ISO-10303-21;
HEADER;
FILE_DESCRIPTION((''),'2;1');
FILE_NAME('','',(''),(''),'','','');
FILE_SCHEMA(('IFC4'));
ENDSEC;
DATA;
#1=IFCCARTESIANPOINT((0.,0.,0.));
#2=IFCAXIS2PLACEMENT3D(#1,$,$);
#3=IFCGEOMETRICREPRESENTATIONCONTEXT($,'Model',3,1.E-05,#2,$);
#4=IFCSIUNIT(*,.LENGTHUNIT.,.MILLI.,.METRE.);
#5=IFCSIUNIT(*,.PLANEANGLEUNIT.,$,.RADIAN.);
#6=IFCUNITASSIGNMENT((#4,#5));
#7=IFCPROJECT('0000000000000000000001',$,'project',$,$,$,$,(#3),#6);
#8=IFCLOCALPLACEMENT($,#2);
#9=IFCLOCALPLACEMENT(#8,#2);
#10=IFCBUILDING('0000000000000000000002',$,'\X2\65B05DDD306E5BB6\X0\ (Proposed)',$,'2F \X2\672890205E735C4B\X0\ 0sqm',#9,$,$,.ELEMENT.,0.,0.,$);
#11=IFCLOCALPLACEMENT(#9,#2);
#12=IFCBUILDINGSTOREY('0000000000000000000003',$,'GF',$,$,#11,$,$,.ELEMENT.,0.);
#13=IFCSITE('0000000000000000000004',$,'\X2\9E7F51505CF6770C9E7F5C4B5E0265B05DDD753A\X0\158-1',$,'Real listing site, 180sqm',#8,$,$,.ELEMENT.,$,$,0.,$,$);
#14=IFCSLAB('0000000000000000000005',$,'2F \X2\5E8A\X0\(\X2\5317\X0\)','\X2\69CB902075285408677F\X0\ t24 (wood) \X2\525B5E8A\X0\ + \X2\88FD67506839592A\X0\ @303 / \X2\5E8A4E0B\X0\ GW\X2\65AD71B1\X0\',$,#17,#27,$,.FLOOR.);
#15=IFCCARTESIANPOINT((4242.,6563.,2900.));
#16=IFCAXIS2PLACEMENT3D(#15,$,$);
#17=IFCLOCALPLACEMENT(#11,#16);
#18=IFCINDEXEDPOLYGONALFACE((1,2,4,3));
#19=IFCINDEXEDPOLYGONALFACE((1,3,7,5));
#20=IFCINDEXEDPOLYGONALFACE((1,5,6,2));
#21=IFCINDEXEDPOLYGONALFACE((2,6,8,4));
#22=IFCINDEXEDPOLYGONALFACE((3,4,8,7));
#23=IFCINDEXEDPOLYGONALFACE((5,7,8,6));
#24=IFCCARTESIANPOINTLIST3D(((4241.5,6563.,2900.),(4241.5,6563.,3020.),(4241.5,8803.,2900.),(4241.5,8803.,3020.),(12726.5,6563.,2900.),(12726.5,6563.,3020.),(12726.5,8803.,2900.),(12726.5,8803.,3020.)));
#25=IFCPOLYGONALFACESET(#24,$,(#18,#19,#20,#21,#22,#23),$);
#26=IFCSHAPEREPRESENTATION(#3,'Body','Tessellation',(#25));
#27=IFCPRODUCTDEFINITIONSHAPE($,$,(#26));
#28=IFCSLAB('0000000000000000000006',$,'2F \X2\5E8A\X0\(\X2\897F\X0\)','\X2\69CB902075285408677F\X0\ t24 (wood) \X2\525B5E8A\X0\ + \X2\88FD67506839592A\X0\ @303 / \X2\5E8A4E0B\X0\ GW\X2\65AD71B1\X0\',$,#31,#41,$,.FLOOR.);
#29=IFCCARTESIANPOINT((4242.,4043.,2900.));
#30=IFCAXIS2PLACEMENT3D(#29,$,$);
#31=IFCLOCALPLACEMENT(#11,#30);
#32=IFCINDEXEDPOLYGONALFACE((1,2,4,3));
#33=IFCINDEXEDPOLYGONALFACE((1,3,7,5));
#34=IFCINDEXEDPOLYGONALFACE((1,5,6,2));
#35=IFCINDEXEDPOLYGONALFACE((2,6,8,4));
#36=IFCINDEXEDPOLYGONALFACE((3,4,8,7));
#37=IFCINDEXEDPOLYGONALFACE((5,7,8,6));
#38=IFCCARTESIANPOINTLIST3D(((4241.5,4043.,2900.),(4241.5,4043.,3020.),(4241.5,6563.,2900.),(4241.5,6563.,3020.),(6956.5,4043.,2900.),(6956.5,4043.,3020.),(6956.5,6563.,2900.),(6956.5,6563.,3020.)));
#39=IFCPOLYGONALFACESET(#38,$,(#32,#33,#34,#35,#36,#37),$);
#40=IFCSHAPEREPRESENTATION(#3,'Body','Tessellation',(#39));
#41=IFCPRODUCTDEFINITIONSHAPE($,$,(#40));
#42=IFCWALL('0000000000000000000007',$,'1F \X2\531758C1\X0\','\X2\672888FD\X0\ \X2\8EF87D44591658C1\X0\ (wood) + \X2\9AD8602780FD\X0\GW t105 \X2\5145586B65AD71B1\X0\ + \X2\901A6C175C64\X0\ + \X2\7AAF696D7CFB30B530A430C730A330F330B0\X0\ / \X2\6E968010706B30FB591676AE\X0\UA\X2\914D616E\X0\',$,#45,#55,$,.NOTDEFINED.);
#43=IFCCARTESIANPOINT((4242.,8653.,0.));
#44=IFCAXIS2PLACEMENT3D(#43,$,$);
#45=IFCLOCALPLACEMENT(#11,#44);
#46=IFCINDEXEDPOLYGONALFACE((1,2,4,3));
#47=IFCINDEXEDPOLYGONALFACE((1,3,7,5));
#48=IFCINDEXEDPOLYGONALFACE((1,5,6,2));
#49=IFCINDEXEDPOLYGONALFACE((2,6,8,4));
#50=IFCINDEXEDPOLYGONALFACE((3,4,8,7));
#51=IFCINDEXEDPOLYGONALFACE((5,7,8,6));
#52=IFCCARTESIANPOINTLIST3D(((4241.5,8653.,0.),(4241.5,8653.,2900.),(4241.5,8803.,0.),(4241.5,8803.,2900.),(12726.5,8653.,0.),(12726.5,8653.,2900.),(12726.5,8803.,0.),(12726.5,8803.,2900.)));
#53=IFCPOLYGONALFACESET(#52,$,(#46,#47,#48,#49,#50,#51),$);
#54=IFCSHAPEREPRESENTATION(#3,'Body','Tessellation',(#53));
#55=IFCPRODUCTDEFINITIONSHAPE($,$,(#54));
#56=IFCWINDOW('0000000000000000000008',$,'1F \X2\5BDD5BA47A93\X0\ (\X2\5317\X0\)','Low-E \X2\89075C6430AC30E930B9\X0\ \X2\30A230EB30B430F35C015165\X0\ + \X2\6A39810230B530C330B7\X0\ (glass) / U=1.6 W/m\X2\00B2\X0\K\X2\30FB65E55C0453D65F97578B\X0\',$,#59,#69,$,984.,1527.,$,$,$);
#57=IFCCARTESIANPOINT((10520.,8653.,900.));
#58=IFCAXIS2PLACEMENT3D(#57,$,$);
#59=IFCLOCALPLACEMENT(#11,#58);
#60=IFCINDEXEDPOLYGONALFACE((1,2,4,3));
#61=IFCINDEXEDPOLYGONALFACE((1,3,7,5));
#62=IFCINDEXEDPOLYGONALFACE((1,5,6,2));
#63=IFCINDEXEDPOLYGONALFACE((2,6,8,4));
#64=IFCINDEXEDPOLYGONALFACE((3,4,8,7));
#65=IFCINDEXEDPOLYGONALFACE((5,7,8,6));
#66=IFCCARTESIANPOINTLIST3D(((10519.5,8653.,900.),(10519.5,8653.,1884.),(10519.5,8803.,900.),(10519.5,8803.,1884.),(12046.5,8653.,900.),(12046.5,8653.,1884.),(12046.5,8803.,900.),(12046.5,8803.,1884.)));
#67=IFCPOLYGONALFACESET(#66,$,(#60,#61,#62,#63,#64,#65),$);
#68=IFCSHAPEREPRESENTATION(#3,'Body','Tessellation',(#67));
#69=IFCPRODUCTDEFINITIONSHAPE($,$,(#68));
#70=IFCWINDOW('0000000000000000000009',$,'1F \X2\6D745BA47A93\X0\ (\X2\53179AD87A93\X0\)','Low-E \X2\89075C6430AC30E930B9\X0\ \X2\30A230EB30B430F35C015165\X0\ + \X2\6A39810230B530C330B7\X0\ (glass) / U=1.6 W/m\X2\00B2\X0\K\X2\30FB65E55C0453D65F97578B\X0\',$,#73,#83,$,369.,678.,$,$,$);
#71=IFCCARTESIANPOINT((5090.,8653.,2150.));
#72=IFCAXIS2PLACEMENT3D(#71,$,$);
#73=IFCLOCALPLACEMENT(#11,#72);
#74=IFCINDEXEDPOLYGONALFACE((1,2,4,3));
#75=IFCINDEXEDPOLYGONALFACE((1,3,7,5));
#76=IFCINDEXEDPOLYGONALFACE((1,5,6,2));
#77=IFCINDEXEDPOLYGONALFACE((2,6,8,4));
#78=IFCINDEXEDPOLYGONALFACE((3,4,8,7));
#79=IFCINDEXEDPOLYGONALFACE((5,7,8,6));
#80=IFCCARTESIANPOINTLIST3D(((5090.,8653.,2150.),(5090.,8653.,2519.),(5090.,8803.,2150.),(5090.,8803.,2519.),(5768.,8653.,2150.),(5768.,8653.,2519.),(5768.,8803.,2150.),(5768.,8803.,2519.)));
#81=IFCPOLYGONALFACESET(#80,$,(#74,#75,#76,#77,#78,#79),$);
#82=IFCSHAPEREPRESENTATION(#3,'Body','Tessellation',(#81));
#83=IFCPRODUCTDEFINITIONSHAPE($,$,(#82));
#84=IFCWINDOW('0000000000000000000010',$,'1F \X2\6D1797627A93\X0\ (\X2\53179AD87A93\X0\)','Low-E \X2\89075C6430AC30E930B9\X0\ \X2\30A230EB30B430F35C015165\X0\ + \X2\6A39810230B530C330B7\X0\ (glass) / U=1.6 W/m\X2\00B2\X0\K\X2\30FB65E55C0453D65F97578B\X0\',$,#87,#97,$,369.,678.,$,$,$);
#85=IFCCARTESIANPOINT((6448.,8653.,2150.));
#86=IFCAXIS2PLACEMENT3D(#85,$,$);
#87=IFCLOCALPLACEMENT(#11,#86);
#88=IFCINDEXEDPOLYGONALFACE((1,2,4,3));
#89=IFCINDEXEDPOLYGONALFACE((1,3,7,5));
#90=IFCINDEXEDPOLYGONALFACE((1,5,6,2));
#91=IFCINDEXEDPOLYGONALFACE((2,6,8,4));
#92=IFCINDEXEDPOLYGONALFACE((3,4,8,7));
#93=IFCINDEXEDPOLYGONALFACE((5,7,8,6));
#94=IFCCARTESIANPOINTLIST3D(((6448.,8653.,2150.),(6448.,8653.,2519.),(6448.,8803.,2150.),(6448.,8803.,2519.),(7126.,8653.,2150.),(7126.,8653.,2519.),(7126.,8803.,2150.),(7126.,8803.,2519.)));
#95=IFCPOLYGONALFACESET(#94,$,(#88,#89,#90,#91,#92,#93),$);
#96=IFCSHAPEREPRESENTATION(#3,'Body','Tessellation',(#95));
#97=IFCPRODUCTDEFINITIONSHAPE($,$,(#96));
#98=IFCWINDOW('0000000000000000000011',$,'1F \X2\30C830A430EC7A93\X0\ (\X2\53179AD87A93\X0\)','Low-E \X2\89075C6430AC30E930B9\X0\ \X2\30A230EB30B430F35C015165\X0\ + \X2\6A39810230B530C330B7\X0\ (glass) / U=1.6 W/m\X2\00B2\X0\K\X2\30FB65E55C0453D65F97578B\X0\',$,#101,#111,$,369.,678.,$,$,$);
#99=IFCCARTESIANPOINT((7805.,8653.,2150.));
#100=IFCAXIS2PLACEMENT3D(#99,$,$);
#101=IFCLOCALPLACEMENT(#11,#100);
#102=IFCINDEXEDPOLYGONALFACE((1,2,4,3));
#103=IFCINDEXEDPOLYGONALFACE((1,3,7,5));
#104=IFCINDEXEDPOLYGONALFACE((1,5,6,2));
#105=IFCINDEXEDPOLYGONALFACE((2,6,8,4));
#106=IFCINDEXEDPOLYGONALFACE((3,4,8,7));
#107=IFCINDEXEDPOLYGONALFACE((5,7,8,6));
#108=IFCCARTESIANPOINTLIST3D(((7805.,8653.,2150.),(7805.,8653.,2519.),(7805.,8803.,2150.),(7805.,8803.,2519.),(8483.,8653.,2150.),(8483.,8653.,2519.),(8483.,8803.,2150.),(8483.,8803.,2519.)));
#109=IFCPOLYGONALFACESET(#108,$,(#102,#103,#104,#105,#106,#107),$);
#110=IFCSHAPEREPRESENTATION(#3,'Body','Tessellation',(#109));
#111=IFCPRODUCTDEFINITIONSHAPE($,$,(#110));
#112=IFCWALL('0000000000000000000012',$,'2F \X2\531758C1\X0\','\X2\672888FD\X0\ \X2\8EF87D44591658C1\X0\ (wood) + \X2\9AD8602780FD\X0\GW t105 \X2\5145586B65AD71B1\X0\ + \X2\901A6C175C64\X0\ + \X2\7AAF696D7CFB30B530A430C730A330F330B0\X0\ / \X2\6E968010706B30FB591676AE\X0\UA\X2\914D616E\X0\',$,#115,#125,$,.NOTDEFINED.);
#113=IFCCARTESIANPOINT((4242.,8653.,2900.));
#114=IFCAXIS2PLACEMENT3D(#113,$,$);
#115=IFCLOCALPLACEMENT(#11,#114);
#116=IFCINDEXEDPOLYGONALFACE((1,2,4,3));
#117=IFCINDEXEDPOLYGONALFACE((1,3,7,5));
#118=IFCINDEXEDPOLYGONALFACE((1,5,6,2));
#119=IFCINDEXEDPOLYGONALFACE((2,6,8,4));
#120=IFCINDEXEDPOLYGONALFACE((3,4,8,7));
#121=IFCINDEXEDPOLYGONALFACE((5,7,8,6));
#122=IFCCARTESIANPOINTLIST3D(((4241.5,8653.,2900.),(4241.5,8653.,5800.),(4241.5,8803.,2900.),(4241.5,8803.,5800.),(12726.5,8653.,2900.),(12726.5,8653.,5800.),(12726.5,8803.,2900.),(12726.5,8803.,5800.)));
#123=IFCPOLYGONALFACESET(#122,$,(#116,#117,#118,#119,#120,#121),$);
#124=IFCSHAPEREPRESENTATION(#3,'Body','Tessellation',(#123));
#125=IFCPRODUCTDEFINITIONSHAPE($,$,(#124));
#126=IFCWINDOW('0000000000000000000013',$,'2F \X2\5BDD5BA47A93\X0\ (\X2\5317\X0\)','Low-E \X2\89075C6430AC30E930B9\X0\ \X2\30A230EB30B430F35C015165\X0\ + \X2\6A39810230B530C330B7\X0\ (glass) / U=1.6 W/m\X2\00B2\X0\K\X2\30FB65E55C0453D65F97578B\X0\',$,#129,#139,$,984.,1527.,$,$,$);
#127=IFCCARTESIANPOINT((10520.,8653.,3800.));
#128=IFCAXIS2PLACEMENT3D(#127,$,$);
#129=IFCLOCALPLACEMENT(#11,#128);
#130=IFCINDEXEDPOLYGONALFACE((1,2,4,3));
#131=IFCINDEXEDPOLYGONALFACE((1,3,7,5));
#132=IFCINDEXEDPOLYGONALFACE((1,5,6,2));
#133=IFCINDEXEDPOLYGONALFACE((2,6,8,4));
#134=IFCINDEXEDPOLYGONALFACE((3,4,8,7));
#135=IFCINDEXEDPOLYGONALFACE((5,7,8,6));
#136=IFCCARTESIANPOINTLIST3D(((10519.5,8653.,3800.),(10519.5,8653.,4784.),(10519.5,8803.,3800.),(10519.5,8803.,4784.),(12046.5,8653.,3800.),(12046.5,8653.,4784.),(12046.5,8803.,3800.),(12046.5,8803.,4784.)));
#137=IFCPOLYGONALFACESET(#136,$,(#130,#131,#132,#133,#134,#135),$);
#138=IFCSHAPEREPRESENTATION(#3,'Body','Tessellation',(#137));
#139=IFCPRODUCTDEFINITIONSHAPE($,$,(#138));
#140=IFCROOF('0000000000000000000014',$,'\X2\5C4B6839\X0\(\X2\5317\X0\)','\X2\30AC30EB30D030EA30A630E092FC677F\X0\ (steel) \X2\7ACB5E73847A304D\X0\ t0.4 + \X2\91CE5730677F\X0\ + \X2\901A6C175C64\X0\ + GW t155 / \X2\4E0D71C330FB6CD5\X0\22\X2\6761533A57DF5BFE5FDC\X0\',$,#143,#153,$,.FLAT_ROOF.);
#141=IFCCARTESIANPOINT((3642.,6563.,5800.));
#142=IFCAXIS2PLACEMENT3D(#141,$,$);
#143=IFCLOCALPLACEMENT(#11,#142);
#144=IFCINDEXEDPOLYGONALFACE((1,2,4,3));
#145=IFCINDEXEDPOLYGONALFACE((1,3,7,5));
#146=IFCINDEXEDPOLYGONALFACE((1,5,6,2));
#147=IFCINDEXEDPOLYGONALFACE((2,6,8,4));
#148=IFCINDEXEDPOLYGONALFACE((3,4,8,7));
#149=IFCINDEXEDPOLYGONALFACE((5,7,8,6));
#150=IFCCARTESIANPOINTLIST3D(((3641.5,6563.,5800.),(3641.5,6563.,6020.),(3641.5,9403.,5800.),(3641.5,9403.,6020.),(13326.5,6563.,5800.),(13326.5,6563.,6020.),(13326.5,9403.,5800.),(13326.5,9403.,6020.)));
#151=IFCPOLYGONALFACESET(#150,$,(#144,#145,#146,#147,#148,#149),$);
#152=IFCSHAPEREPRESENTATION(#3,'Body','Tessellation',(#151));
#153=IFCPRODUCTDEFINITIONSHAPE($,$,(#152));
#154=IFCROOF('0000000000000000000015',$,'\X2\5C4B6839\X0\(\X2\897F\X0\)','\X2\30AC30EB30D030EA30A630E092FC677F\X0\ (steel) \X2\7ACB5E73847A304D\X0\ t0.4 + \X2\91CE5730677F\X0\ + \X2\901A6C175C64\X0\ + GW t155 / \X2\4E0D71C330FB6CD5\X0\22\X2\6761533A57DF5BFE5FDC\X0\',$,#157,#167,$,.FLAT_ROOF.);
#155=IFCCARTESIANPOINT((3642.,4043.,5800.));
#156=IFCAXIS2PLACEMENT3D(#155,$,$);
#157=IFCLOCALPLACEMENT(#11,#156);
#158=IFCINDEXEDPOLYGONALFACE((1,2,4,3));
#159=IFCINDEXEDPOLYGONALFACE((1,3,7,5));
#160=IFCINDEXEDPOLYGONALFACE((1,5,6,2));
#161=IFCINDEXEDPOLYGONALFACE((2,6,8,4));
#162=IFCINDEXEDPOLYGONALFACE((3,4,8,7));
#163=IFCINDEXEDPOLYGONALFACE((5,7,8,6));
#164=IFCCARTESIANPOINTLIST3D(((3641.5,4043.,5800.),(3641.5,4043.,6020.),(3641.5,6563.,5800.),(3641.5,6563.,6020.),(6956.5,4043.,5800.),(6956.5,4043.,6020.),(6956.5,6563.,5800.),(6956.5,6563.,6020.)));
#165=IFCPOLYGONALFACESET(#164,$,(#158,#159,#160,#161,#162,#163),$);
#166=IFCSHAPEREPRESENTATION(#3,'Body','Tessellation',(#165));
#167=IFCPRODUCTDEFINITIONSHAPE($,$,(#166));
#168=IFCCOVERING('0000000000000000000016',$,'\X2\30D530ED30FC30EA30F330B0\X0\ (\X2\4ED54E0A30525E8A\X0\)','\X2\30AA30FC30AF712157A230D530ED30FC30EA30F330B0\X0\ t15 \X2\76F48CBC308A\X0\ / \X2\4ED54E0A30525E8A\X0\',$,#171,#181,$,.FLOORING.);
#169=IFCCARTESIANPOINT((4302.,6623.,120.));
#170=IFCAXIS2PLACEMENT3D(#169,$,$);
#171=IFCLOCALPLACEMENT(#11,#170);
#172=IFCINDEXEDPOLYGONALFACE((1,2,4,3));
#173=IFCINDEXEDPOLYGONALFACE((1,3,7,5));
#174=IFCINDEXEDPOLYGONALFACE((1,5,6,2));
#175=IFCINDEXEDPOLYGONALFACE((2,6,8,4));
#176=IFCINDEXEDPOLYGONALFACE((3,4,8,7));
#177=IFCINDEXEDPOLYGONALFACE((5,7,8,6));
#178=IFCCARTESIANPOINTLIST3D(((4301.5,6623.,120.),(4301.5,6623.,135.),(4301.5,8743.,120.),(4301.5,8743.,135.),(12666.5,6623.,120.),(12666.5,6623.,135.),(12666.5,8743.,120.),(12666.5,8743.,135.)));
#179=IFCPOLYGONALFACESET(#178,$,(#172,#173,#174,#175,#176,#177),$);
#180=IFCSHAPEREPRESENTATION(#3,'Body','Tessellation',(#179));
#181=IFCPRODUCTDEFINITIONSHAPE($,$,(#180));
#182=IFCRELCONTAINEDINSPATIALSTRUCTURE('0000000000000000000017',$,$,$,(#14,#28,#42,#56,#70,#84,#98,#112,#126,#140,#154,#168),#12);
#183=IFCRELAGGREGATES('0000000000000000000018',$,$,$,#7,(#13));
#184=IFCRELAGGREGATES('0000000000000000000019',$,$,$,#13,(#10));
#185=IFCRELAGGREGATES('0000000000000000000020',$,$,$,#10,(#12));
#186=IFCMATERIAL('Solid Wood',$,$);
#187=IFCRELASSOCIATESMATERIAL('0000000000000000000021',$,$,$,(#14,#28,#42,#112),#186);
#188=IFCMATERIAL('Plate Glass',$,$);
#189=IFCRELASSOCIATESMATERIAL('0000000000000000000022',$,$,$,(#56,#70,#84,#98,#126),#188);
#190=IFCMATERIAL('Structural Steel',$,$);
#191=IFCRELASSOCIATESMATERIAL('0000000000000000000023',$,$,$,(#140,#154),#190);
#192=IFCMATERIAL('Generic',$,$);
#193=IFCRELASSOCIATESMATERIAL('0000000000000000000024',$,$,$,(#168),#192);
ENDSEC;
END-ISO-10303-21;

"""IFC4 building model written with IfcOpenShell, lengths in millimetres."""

from ifc_helpers import new_model, si_unit, frame, frame_2d, origin, place, context, project, spatial, rectangle, extrude, material, element, fill, save


model = new_model("IFC4")

# Units and contexts
model_context = context("Model", 3, precision=1e-05, world=origin())
ifc_project = project(units=[si_unit("LENGTHUNIT", "METRE", prefix="MILLI"), si_unit("PLANEANGLEUNIT", "RADIAN")], contexts=[model_context])

# Site, building, storey
site_placement = place(None, origin())
site = spatial("IfcSite", under=ifc_project, at=site_placement, Name="鹿児島県鹿屋市新川町158-1", ObjectType="Real listing site, 180sqm", CompositionType="ELEMENT", RefElevation=0.0)
building_placement = place(site_placement, origin())
building = spatial("IfcBuilding", under=site, at=building_placement, Name="新川の家 (Proposed)", ObjectType="2F 木造平屋 0sqm", CompositionType="ELEMENT", ElevationOfRefHeight=0.0, ElevationOfTerrain=0.0)
storey_placement = place(building_placement, origin())
storey = spatial("IfcBuildingStorey", under=building, at=storey_placement, Name="GF", CompositionType="ELEMENT", Elevation=0.0)

# Slabs
ifc_material_1 = material(Name="Solid Wood")
slab_1_placement = place(storey_placement, frame((4242.0, 6563.0, 2900.0)))
element("IfcSlab", 1, at=slab_1_placement, inside=storey, material=ifc_material_1, Name="2F 床(北)", Description="構造用合板 t24 (wood) 剛床 + 製材根太 @303 / 床下 GW断熱", PredefinedType="FLOOR", context=model_context, shape_type="SweptSolid", body=[
    extrude(rectangle(XDim=8485.0, YDim=2240.0, at=frame_2d((4242.0, 1120.0))), frame((4242.0, 6563.0, 2900.0)), (0.0, 0.0, 1.0), 120.0),
])
slab_2_placement = place(storey_placement, frame((4242.0, 4043.0, 2900.0)))
element("IfcSlab", 2, at=slab_2_placement, inside=storey, material=ifc_material_1, Name="2F 床(西)", Description="構造用合板 t24 (wood) 剛床 + 製材根太 @303 / 床下 GW断熱", PredefinedType="FLOOR", context=model_context, shape_type="SweptSolid", body=[
    extrude(rectangle(XDim=2715.0, YDim=2520.0, at=frame_2d((1357.0, 1260.0))), frame((4242.0, 4043.0, 2900.0)), (0.0, 0.0, 1.0), 120.0),
])

# Wall, openings, windows
wall_1_placement = place(storey_placement, frame((4242.0, 8653.0, 0.0)))
wall_1 = element("IfcWall", 3, at=wall_1_placement, inside=storey, material=ifc_material_1, Name="1F 北壁", Description="木製 軸組外壁 (wood) + 高性能GW t105 充填断熱 + 通気層 + 窯業系サイディング / 準耐火・外皮UA配慮", PredefinedType="NOTDEFINED", context=model_context, shape_type="SweptSolid", body=[
    extrude(rectangle(XDim=8485.0, YDim=150.0, at=frame_2d((4242.0, 75.0))), frame((4242.0, 8653.0, 0.0)), (0.0, 0.0, 1.0), 2900.0),
])
opening_1_placement = place(storey_placement, frame((10520.0, 8653.0, 900.0)))
opening_1 = element("IfcOpeningElement", 4, at=opening_1_placement, cuts=wall_1, PredefinedType="NOTDEFINED", context=model_context, shape_type="SweptSolid", body=[
    extrude(rectangle(XDim=1527.0, YDim=150.0, at=frame_2d((763.0, 75.0))), frame((10520.0, 8653.0, 900.0)), (0.0, 0.0, 1.0), 984.0),
])
opening_2_placement = place(storey_placement, frame((5090.0, 8653.0, 2150.0)))
opening_2 = element("IfcOpeningElement", 5, at=opening_2_placement, cuts=wall_1, PredefinedType="NOTDEFINED", context=model_context, shape_type="SweptSolid", body=[
    extrude(rectangle(XDim=678.0, YDim=150.0, at=frame_2d((339.0, 75.0))), frame((5090.0, 8653.0, 2150.0)), (0.0, 0.0, 1.0), 369.0),
])
opening_3_placement = place(storey_placement, frame((6448.0, 8653.0, 2150.0)))
opening_3 = element("IfcOpeningElement", 6, at=opening_3_placement, cuts=wall_1, PredefinedType="NOTDEFINED", context=model_context, shape_type="SweptSolid", body=[
    extrude(rectangle(XDim=678.0, YDim=150.0, at=frame_2d((339.0, 75.0))), frame((6448.0, 8653.0, 2150.0)), (0.0, 0.0, 1.0), 369.0),
])
opening_4_placement = place(storey_placement, frame((7805.0, 8653.0, 2150.0)))
opening_4 = element("IfcOpeningElement", 7, at=opening_4_placement, cuts=wall_1, PredefinedType="NOTDEFINED", context=model_context, shape_type="SweptSolid", body=[
    extrude(rectangle(XDim=678.0, YDim=150.0, at=frame_2d((339.0, 75.0))), frame((7805.0, 8653.0, 2150.0)), (0.0, 0.0, 1.0), 369.0),
])
ifc_material_2 = material(Name="Plate Glass")
window_1_placement = place(storey_placement, frame((10520.0, 8653.0, 900.0)))
window_1 = element("IfcWindow", 8, at=window_1_placement, inside=storey, material=ifc_material_2, Name="1F 寝室窓 (北)", Description="Low-E 複層ガラス アルゴン封入 + 樹脂サッシ (glass) / U=1.6 W/m²K・日射取得型", OverallHeight=984.0, OverallWidth=1527.0, context=model_context, shape_type="SweptSolid", body=[
    extrude(rectangle(XDim=1527.0, YDim=150.0, at=frame_2d((763.0, 75.0))), frame((10520.0, 8653.0, 900.0)), (0.0, 0.0, 1.0), 984.0),
])
fill(opening_1, window_1)
window_2_placement = place(storey_placement, frame((5090.0, 8653.0, 2150.0)))
window_2 = element("IfcWindow", 9, at=window_2_placement, inside=storey, material=ifc_material_2, Name="1F 浴室窓 (北高窓)", Description="Low-E 複層ガラス アルゴン封入 + 樹脂サッシ (glass) / U=1.6 W/m²K・日射取得型", OverallHeight=369.0, OverallWidth=678.0, context=model_context, shape_type="SweptSolid", body=[
    extrude(rectangle(XDim=678.0, YDim=150.0, at=frame_2d((339.0, 75.0))), frame((5090.0, 8653.0, 2150.0)), (0.0, 0.0, 1.0), 369.0),
])
fill(opening_2, window_2)
window_3_placement = place(storey_placement, frame((6448.0, 8653.0, 2150.0)))
window_3 = element("IfcWindow", 10, at=window_3_placement, inside=storey, material=ifc_material_2, Name="1F 洗面窓 (北高窓)", Description="Low-E 複層ガラス アルゴン封入 + 樹脂サッシ (glass) / U=1.6 W/m²K・日射取得型", OverallHeight=369.0, OverallWidth=678.0, context=model_context, shape_type="SweptSolid", body=[
    extrude(rectangle(XDim=678.0, YDim=150.0, at=frame_2d((339.0, 75.0))), frame((6448.0, 8653.0, 2150.0)), (0.0, 0.0, 1.0), 369.0),
])
fill(opening_3, window_3)
window_4_placement = place(storey_placement, frame((7805.0, 8653.0, 2150.0)))
window_4 = element("IfcWindow", 11, at=window_4_placement, inside=storey, material=ifc_material_2, Name="1F トイレ窓 (北高窓)", Description="Low-E 複層ガラス アルゴン封入 + 樹脂サッシ (glass) / U=1.6 W/m²K・日射取得型", OverallHeight=369.0, OverallWidth=678.0, context=model_context, shape_type="SweptSolid", body=[
    extrude(rectangle(XDim=678.0, YDim=150.0, at=frame_2d((339.0, 75.0))), frame((7805.0, 8653.0, 2150.0)), (0.0, 0.0, 1.0), 369.0),
])
fill(opening_4, window_4)

# Wall, opening, window
wall_2_placement = place(storey_placement, frame((4242.0, 8653.0, 2900.0)))
wall_2 = element("IfcWall", 12, at=wall_2_placement, inside=storey, material=ifc_material_1, Name="2F 北壁", Description="木製 軸組外壁 (wood) + 高性能GW t105 充填断熱 + 通気層 + 窯業系サイディング / 準耐火・外皮UA配慮", PredefinedType="NOTDEFINED", context=model_context, shape_type="SweptSolid", body=[
    extrude(rectangle(XDim=8485.0, YDim=150.0, at=frame_2d((4242.0, 75.0))), frame((4242.0, 8653.0, 2900.0)), (0.0, 0.0, 1.0), 2900.0),
])
opening_5_placement = place(storey_placement, frame((10520.0, 8653.0, 3800.0)))
opening_5 = element("IfcOpeningElement", 13, at=opening_5_placement, cuts=wall_2, PredefinedType="NOTDEFINED", context=model_context, shape_type="SweptSolid", body=[
    extrude(rectangle(XDim=1527.0, YDim=150.0, at=frame_2d((763.0, 75.0))), frame((10520.0, 8653.0, 3800.0)), (0.0, 0.0, 1.0), 984.0),
])
window_5_placement = place(storey_placement, frame((10520.0, 8653.0, 3800.0)))
window_5 = element("IfcWindow", 14, at=window_5_placement, inside=storey, material=ifc_material_2, Name="2F 寝室窓 (北)", Description="Low-E 複層ガラス アルゴン封入 + 樹脂サッシ (glass) / U=1.6 W/m²K・日射取得型", OverallHeight=984.0, OverallWidth=1527.0, context=model_context, shape_type="SweptSolid", body=[
    extrude(rectangle(XDim=1527.0, YDim=150.0, at=frame_2d((763.0, 75.0))), frame((10520.0, 8653.0, 3800.0)), (0.0, 0.0, 1.0), 984.0),
])
fill(opening_5, window_5)

# Roofs
ifc_material_3 = material(Name="Structural Steel")
for number, where, name in (
    (15, (3642.0, 6563.0, 5800.0), "屋根(北)"),
):
    element("IfcRoof", number, at=place(storey_placement, frame(where)), inside=storey, material=ifc_material_3, Name=name, Description="ガルバリウム鋼板 (steel) 立平葺き t0.4 + 野地板 + 通気層 + GW t155 / 不燃・法22条区域対応", PredefinedType="FLAT_ROOF", context=model_context, shape_type="SweptSolid", body=[
        extrude(rectangle(XDim=9685.0, YDim=2840.0, at=frame_2d((4842.0, 1420.0))), frame((3642.0, 6563.0, 5800.0)), (0.0, 0.0, 1.0), 220.0),
    ])
roof_placement = place(storey_placement, frame((3642.0, 4043.0, 5800.0)))
element("IfcRoof", 16, at=roof_placement, inside=storey, material=ifc_material_3, Name="屋根(西)", Description="ガルバリウム鋼板 (steel) 立平葺き t0.4 + 野地板 + 通気層 + GW t155 / 不燃・法22条区域対応", PredefinedType="FLAT_ROOF", context=model_context, shape_type="SweptSolid", body=[
    extrude(rectangle(XDim=3315.0, YDim=2520.0, at=frame_2d((1657.0, 1260.0))), frame((3642.0, 4043.0, 5800.0)), (0.0, 0.0, 1.0), 220.0),
])

# Covering
ifc_material_4 = material(Name="Generic")
covering_1_placement = place(storey_placement, frame((4302.0, 6623.0, 120.0)))
element("IfcCovering", 17, at=covering_1_placement, inside=storey, material=ifc_material_4, Name="フローリング (仕上げ床)", Description="オーク無垢フローリング t15 直貼り / 仕上げ床", PredefinedType="FLOORING", context=model_context, shape_type="SweptSolid", body=[
    extrude(rectangle(XDim=8365.0, YDim=2120.0, at=frame_2d((4182.0, 1060.0))), frame((4302.0, 6623.0, 120.0)), (0.0, 0.0, 1.0), 15.0),
])

save(model, "model.ifc")
